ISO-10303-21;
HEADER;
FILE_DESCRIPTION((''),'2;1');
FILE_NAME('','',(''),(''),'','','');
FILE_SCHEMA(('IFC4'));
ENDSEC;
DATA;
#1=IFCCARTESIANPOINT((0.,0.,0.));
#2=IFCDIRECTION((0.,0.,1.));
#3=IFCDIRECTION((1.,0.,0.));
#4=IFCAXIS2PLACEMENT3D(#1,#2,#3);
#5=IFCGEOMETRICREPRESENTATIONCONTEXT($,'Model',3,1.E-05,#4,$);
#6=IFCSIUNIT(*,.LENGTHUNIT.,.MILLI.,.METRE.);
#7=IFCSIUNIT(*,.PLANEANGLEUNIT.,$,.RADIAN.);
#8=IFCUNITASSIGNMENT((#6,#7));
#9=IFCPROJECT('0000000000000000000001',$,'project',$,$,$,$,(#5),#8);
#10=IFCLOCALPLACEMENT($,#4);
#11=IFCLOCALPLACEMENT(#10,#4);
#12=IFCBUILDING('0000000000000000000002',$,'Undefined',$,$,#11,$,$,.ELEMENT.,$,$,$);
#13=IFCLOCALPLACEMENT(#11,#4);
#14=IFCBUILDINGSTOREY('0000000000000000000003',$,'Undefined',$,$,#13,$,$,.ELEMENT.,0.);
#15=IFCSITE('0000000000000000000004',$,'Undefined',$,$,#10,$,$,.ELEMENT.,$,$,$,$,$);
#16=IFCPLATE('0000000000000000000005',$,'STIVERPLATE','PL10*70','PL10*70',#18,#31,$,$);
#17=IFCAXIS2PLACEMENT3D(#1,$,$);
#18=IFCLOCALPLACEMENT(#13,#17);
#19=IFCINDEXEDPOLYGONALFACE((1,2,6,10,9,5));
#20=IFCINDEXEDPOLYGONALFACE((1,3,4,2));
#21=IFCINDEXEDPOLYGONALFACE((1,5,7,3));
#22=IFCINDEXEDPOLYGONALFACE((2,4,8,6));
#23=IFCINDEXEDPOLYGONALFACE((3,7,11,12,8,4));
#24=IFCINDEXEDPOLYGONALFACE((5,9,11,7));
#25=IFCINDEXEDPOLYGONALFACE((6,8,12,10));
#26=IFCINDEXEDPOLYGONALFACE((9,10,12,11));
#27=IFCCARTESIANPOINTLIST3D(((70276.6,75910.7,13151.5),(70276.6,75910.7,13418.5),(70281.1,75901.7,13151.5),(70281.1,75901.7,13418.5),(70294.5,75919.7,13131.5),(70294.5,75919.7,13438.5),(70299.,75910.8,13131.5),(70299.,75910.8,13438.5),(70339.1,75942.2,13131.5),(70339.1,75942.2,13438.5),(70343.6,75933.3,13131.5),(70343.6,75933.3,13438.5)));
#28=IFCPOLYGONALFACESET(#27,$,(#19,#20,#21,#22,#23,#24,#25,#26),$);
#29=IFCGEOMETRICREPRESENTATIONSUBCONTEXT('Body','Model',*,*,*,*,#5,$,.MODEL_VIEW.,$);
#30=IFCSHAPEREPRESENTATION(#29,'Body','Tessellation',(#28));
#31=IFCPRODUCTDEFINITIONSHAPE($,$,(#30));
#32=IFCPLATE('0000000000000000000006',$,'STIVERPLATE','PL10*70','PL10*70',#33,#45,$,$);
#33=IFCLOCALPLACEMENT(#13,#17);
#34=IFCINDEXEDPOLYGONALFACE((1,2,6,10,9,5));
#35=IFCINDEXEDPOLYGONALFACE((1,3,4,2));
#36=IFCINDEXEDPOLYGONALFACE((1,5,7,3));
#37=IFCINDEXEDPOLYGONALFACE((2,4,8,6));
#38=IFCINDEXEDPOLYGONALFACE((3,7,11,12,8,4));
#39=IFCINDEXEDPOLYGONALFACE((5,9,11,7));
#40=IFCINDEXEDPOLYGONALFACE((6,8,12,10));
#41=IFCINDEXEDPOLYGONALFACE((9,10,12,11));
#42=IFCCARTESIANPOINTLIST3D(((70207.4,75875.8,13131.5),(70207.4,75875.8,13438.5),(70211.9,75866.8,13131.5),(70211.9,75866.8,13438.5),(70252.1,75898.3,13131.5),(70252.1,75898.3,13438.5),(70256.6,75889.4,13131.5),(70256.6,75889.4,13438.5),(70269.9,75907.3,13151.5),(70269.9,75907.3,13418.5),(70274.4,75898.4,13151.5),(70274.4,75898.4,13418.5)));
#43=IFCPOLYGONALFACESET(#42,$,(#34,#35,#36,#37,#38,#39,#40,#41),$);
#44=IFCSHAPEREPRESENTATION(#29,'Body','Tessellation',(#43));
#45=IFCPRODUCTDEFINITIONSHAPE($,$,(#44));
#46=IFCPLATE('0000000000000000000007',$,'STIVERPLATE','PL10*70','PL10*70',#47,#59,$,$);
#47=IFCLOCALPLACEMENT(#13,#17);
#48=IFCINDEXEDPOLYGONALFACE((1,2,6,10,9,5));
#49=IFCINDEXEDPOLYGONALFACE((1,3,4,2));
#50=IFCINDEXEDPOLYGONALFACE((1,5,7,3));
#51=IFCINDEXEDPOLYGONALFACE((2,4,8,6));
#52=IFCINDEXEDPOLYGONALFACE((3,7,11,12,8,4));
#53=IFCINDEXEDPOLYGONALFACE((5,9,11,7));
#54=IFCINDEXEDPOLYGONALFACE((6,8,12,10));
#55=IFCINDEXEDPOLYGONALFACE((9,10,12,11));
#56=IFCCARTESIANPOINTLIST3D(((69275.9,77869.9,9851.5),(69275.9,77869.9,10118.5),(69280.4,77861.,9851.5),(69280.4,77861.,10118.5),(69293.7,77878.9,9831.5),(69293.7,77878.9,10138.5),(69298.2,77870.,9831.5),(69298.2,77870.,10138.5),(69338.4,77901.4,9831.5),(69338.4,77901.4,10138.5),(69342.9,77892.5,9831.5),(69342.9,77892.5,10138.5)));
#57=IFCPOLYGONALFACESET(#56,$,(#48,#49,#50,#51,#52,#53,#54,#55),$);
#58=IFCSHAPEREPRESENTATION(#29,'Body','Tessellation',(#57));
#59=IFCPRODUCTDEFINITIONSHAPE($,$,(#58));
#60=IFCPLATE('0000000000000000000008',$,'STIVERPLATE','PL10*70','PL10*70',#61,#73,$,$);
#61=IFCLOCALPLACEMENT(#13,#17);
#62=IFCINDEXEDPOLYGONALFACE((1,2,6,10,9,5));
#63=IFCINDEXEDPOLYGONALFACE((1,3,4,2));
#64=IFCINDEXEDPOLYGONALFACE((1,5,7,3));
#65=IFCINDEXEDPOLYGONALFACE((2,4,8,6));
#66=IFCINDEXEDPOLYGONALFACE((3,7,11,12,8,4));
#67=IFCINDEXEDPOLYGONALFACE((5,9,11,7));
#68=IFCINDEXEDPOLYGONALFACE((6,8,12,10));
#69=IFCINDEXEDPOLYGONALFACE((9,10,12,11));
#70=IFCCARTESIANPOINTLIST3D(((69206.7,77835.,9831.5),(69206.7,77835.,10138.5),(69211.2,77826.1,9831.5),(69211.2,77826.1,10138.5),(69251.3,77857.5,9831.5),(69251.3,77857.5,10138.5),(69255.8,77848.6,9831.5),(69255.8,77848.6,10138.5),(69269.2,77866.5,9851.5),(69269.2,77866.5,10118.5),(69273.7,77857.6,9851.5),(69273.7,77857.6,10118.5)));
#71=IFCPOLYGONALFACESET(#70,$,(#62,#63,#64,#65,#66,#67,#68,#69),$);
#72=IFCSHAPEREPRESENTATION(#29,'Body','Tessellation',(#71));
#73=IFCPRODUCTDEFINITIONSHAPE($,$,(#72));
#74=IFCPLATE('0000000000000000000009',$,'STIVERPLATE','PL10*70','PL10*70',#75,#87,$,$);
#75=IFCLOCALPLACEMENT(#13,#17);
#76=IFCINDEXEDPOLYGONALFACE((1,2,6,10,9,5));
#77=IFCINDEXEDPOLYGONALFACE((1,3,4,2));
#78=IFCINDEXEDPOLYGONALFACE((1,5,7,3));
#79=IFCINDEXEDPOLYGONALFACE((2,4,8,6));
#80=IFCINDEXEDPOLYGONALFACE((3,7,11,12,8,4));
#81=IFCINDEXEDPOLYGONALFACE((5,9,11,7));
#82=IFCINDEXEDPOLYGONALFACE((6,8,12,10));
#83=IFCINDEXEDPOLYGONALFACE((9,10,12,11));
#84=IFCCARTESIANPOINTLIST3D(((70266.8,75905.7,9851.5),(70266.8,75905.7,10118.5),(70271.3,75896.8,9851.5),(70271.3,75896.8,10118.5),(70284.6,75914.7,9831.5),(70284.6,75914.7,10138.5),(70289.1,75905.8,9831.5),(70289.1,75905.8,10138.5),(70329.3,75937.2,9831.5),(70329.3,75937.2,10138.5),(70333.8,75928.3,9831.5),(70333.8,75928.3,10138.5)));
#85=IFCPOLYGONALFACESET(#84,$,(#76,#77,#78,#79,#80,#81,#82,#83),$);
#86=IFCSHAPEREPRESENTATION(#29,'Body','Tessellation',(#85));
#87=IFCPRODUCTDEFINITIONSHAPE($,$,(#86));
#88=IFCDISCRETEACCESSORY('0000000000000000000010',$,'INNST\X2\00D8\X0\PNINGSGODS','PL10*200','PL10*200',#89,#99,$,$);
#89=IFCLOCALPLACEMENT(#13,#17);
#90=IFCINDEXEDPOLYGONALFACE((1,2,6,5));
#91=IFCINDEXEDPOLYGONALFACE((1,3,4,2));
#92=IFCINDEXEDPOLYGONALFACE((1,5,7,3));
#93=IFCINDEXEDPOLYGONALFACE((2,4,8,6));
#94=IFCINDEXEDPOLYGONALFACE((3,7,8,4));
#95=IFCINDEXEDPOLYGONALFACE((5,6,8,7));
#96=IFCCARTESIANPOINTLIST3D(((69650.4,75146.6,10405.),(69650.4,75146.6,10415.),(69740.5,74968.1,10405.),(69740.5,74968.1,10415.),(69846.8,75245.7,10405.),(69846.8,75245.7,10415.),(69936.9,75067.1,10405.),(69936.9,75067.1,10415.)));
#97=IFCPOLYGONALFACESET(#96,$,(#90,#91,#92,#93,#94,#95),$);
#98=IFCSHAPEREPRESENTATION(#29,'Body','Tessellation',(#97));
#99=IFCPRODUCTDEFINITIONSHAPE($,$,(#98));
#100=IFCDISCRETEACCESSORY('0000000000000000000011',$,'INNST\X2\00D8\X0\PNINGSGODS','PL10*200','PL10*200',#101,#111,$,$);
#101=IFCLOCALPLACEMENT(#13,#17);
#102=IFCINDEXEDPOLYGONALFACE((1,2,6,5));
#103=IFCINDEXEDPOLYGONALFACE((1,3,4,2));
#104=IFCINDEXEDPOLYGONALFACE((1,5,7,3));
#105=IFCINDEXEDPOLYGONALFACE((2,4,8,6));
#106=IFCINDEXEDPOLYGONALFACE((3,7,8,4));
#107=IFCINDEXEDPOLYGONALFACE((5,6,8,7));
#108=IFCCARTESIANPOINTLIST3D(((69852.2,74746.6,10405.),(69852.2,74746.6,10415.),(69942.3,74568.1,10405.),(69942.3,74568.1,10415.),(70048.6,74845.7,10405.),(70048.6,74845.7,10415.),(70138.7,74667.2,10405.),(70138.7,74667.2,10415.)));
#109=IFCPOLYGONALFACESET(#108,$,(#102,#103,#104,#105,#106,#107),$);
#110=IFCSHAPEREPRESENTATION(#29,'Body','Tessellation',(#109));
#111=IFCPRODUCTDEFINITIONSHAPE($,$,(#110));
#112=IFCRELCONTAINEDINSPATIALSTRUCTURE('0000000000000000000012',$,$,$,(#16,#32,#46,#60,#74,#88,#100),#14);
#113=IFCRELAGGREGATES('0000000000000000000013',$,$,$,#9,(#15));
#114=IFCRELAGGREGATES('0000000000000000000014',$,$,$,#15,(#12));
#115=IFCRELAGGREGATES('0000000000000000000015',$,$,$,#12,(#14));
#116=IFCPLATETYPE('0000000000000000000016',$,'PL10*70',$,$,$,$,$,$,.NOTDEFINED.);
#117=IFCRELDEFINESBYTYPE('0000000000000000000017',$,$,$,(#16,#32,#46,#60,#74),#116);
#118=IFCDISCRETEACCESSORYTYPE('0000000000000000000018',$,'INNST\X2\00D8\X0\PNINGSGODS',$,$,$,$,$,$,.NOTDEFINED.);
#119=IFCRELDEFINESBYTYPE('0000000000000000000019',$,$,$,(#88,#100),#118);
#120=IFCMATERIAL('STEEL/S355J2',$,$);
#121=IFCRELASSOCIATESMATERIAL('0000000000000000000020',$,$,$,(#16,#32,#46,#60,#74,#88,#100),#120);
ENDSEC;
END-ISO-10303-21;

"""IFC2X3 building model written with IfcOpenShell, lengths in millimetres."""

from ifc_helpers import new_model, si_unit, frame, origin_with_axes, place, context, subcontext, project, spatial, polyline, outline, extrude, material, type_object, element, save


model = new_model("IFC2X3")

# Units and contexts
model_context = context("Model", 3, precision=1e-05, world=origin_with_axes())
body_context = subcontext(model_context, "Body", "Model", "MODEL_VIEW")
ifc_project = project(units=[si_unit("LENGTHUNIT", "METRE", prefix="MILLI"), si_unit("PLANEANGLEUNIT", "RADIAN")], contexts=[model_context])

# Site, building, storey
site_placement = place(None, origin_with_axes())
site = spatial("IfcSite", under=ifc_project, at=site_placement, Name="Undefined", CompositionType="ELEMENT")
building_placement = place(site_placement, origin_with_axes())
building = spatial("IfcBuilding", under=site, at=building_placement, Name="Undefined", CompositionType="ELEMENT")
storey_placement = place(building_placement, origin_with_axes())
storey = spatial("IfcBuildingStorey", under=building, at=storey_placement, Name="Undefined", CompositionType="ELEMENT", Elevation=0.0)

# Plates
ifc_material_1 = material(Name="STEEL/S355J2")
plate_type_1 = type_object("IfcPlateType", Name="PL10*70", PredefinedType="NOTDEFINED")
plate_1_placement = place(storey_placement, frame((70341.4, 75937.7, 13131.5), z_axis=(-0.450411, 0.892821, 0.0), x_axis=(-0.892821, -0.450411, 0.0)))
element("IfcPlate", 1, at=plate_1_placement, inside=storey, type_object=plate_type_1, material=ifc_material_1, Name="STIVERPLATE", Description="PL10*70", ObjectType="PL10*70", context=body_context, shape_type="SweptSolid", body=[
    extrude(outline(polyline([(0.0, 0.0), (50.0, 0.0), (70.0, 20.0), (70.0, 287.0), (50.0, 307.0), (0.0, 307.0), (0.0, 0.0)])), frame((0.0, 0.0, -5.0), z_axis=(0.0, 0.0, 1.0), x_axis=(1.0, 0.0, 0.0)), (0.0, 0.0, 1.0), 10.0),
])
plate_2_placement = place(storey_placement, frame((70272.2, 75902.8, 13131.5), z_axis=(-0.450411, 0.892821, 0.0), x_axis=(-0.892821, -0.450411, 0.0)))
element("IfcPlate", 2, at=plate_2_placement, inside=storey, type_object=plate_type_1, material=ifc_material_1, Name="STIVERPLATE", Description="PL10*70", ObjectType="PL10*70", context=body_context, shape_type="SweptSolid", body=[
    extrude(outline(polyline([(0.0, 20.0), (20.0, 0.0), (70.0, 0.0), (70.0, 307.0), (20.0, 307.0), (0.0, 287.0), (0.0, 20.0)])), frame((0.0, 0.0, -5.0), z_axis=(0.0, 0.0, 1.0), x_axis=(1.0, 0.0, 0.0)), (0.0, 0.0, 1.0), 10.0),
])
plate_3_placement = place(storey_placement, frame((69340.6, 77897.0, 9831.5), z_axis=(-0.450411, 0.892821, 0.0), x_axis=(-0.892821, -0.450411, 0.0)))
element("IfcPlate", 3, at=plate_3_placement, inside=storey, type_object=plate_type_1, material=ifc_material_1, Name="STIVERPLATE", Description="PL10*70", ObjectType="PL10*70", context=body_context, shape_type="SweptSolid", body=[
    extrude(outline(polyline([(0.0, 0.0), (50.0, 0.0), (70.0, 20.0), (70.0, 287.0), (50.0, 307.0), (0.0, 307.0), (0.0, 0.0)])), frame((0.0, 0.0, -5.0), z_axis=(0.0, 0.0, 1.0), x_axis=(1.0, 0.0, 0.0)), (0.0, 0.0, 1.0), 10.0),
])
plate_4_placement = place(storey_placement, frame((69271.4, 77862.1, 9831.5), z_axis=(-0.450411, 0.892821, 0.0), x_axis=(-0.892821, -0.450411, 0.0)))
element("IfcPlate", 4, at=plate_4_placement, inside=storey, type_object=plate_type_1, material=ifc_material_1, Name="STIVERPLATE", Description="PL10*70", ObjectType="PL10*70", context=body_context, shape_type="SweptSolid", body=[
    extrude(outline(polyline([(0.0, 20.0), (20.0, 0.0), (70.0, 0.0), (70.0, 307.0), (20.0, 307.0), (0.0, 287.0), (0.0, 20.0)])), frame((0.0, 0.0, -5.0), z_axis=(0.0, 0.0, 1.0), x_axis=(1.0, 0.0, 0.0)), (0.0, 0.0, 1.0), 10.0),
])
plate_5_placement = place(storey_placement, frame((70331.5, 75932.8, 9831.5), z_axis=(-0.450411, 0.892821, 0.0), x_axis=(-0.892821, -0.450411, 0.0)))
element("IfcPlate", 5, at=plate_5_placement, inside=storey, type_object=plate_type_1, material=ifc_material_1, Name="STIVERPLATE", Description="PL10*70", ObjectType="PL10*70", context=body_context, shape_type="SweptSolid", body=[
    extrude(outline(polyline([(0.0, 0.0), (50.0, 0.0), (70.0, 20.0), (70.0, 287.0), (50.0, 307.0), (0.0, 307.0), (0.0, 0.0)])), frame((0.0, 0.0, -5.0), z_axis=(0.0, 0.0, 1.0), x_axis=(1.0, 0.0, 0.0)), (0.0, 0.0, 1.0), 10.0),
])

# Discrete accessories
discrete_accessory_type = type_object("IfcDiscreteAccessoryType", Name="INNSTØPNINGSGODS")
for number, where, z_axis, x_axis, name in (
    (6, (69695.5, 75057.3, 10410.0), (0.0, 0.0, 1.0), (0.892821, 0.450411, 0.0), "INNSTØPNINGSGODS"),
    (7, (69897.2, 74657.4, 10410.0), (0.0, 0.0, 1.0), (0.892821, 0.450411, 0.0), "INNSTØPNINGSGODS"),
):
    element("IfcDiscreteAccessory", number, at=place(storey_placement, frame(where, z_axis=z_axis, x_axis=x_axis)), inside=storey, type_object=discrete_accessory_type, material=ifc_material_1, Name=name, Description="PL10*200", ObjectType="PL10*200", context=body_context, shape_type="SweptSolid", body=[
        extrude(outline(polyline([(0.0, 100.0), (220.0, 100.0), (220.0, -100.0), (0.0, -100.0), (0.0, 100.0)])), frame((0.0, 0.0, -5.0), z_axis=(0.0, 0.0, 1.0), x_axis=(1.0, 0.0, 0.0)), (0.0, 0.0, 1.0), 10.0),
    ])

save(model, "model.ifc")
